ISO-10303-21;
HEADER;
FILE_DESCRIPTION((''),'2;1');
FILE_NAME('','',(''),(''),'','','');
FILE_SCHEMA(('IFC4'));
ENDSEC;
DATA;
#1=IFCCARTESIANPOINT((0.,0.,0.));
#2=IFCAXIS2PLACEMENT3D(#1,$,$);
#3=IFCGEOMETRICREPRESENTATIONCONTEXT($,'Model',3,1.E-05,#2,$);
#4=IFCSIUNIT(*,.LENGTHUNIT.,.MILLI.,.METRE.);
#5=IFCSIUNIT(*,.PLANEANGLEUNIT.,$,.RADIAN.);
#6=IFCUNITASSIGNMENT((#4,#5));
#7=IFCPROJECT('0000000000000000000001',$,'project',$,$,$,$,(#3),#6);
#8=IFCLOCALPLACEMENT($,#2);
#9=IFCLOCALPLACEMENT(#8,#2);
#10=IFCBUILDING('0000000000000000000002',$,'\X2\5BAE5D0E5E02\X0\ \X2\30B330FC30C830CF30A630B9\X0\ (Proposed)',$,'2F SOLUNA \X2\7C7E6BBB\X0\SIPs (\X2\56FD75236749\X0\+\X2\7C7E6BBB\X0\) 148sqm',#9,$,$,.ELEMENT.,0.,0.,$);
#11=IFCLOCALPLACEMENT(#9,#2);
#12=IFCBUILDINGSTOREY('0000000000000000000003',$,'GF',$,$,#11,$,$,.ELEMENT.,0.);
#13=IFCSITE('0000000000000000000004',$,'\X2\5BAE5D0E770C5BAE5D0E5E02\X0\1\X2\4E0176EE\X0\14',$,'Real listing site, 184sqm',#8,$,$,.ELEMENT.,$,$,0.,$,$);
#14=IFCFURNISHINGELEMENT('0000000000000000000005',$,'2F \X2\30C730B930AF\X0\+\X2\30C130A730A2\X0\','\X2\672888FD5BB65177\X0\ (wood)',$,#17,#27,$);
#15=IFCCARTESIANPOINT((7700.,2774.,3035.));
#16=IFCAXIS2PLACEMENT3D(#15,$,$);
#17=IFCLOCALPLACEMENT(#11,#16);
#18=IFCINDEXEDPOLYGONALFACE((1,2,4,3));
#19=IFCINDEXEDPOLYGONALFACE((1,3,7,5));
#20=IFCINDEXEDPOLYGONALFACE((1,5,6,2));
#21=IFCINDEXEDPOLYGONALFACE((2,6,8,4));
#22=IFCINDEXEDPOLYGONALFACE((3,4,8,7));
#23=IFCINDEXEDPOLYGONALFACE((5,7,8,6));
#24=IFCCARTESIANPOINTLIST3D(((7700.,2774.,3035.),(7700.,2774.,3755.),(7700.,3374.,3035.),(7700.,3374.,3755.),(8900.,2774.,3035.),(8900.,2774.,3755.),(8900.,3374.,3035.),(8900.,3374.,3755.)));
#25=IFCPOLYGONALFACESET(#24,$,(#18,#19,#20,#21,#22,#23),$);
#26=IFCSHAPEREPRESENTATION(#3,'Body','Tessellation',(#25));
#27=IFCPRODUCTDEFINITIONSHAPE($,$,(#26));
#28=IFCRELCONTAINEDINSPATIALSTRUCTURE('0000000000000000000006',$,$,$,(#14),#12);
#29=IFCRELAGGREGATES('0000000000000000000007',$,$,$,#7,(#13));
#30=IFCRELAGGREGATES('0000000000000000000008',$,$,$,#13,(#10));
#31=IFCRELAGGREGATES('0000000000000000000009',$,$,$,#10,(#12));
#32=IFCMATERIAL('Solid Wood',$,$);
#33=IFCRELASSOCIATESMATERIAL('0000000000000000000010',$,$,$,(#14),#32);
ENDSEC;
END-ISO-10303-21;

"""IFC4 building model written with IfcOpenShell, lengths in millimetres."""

from ifc_helpers import new_model, si_unit, frame, frame_2d, origin, place, context, project, spatial, rectangle, extrude, material, element, save


model = new_model("IFC4")

# Units and contexts
model_context = context("Model", 3, precision=1e-05, world=origin())
ifc_project = project(units=[si_unit("LENGTHUNIT", "METRE", prefix="MILLI"), si_unit("PLANEANGLEUNIT", "RADIAN")], contexts=[model_context])

# Site, building, storey
site_placement = place(None, origin())
site = spatial("IfcSite", under=ifc_project, at=site_placement, Name="宮崎県宮崎市1丁目14", ObjectType="Real listing site, 184sqm", CompositionType="ELEMENT", RefElevation=0.0)
building_placement = place(site_placement, origin())
building = spatial("IfcBuilding", under=site, at=building_placement, Name="宮崎市 コートハウス (Proposed)", ObjectType="2F SOLUNA 籾殻SIPs (国産杉+籾殻) 148sqm", CompositionType="ELEMENT", ElevationOfRefHeight=0.0, ElevationOfTerrain=0.0)
storey_placement = place(building_placement, origin())
storey = spatial("IfcBuildingStorey", under=building, at=storey_placement, Name="GF", CompositionType="ELEMENT", Elevation=0.0)

# Shared definitions
ifc_material_1 = material(Name="Solid Wood")

# Furnishing element
furnishing_1_placement = place(storey_placement, frame((7700.0, 2774.0, 3035.0)))
element("IfcFurnishingElement", 1, at=furnishing_1_placement, inside=storey, material=ifc_material_1, Name="2F デスク+チェア", Description="木製家具 (wood)", context=model_context, shape_type="SweptSolid", body=[
    extrude(rectangle(XDim=1200.0, YDim=600.0, at=frame_2d((600.0, 300.0))), frame((7700.0, 2774.0, 3035.0)), (0.0, 0.0, 1.0), 720.0),
])

save(model, "model.ifc")
